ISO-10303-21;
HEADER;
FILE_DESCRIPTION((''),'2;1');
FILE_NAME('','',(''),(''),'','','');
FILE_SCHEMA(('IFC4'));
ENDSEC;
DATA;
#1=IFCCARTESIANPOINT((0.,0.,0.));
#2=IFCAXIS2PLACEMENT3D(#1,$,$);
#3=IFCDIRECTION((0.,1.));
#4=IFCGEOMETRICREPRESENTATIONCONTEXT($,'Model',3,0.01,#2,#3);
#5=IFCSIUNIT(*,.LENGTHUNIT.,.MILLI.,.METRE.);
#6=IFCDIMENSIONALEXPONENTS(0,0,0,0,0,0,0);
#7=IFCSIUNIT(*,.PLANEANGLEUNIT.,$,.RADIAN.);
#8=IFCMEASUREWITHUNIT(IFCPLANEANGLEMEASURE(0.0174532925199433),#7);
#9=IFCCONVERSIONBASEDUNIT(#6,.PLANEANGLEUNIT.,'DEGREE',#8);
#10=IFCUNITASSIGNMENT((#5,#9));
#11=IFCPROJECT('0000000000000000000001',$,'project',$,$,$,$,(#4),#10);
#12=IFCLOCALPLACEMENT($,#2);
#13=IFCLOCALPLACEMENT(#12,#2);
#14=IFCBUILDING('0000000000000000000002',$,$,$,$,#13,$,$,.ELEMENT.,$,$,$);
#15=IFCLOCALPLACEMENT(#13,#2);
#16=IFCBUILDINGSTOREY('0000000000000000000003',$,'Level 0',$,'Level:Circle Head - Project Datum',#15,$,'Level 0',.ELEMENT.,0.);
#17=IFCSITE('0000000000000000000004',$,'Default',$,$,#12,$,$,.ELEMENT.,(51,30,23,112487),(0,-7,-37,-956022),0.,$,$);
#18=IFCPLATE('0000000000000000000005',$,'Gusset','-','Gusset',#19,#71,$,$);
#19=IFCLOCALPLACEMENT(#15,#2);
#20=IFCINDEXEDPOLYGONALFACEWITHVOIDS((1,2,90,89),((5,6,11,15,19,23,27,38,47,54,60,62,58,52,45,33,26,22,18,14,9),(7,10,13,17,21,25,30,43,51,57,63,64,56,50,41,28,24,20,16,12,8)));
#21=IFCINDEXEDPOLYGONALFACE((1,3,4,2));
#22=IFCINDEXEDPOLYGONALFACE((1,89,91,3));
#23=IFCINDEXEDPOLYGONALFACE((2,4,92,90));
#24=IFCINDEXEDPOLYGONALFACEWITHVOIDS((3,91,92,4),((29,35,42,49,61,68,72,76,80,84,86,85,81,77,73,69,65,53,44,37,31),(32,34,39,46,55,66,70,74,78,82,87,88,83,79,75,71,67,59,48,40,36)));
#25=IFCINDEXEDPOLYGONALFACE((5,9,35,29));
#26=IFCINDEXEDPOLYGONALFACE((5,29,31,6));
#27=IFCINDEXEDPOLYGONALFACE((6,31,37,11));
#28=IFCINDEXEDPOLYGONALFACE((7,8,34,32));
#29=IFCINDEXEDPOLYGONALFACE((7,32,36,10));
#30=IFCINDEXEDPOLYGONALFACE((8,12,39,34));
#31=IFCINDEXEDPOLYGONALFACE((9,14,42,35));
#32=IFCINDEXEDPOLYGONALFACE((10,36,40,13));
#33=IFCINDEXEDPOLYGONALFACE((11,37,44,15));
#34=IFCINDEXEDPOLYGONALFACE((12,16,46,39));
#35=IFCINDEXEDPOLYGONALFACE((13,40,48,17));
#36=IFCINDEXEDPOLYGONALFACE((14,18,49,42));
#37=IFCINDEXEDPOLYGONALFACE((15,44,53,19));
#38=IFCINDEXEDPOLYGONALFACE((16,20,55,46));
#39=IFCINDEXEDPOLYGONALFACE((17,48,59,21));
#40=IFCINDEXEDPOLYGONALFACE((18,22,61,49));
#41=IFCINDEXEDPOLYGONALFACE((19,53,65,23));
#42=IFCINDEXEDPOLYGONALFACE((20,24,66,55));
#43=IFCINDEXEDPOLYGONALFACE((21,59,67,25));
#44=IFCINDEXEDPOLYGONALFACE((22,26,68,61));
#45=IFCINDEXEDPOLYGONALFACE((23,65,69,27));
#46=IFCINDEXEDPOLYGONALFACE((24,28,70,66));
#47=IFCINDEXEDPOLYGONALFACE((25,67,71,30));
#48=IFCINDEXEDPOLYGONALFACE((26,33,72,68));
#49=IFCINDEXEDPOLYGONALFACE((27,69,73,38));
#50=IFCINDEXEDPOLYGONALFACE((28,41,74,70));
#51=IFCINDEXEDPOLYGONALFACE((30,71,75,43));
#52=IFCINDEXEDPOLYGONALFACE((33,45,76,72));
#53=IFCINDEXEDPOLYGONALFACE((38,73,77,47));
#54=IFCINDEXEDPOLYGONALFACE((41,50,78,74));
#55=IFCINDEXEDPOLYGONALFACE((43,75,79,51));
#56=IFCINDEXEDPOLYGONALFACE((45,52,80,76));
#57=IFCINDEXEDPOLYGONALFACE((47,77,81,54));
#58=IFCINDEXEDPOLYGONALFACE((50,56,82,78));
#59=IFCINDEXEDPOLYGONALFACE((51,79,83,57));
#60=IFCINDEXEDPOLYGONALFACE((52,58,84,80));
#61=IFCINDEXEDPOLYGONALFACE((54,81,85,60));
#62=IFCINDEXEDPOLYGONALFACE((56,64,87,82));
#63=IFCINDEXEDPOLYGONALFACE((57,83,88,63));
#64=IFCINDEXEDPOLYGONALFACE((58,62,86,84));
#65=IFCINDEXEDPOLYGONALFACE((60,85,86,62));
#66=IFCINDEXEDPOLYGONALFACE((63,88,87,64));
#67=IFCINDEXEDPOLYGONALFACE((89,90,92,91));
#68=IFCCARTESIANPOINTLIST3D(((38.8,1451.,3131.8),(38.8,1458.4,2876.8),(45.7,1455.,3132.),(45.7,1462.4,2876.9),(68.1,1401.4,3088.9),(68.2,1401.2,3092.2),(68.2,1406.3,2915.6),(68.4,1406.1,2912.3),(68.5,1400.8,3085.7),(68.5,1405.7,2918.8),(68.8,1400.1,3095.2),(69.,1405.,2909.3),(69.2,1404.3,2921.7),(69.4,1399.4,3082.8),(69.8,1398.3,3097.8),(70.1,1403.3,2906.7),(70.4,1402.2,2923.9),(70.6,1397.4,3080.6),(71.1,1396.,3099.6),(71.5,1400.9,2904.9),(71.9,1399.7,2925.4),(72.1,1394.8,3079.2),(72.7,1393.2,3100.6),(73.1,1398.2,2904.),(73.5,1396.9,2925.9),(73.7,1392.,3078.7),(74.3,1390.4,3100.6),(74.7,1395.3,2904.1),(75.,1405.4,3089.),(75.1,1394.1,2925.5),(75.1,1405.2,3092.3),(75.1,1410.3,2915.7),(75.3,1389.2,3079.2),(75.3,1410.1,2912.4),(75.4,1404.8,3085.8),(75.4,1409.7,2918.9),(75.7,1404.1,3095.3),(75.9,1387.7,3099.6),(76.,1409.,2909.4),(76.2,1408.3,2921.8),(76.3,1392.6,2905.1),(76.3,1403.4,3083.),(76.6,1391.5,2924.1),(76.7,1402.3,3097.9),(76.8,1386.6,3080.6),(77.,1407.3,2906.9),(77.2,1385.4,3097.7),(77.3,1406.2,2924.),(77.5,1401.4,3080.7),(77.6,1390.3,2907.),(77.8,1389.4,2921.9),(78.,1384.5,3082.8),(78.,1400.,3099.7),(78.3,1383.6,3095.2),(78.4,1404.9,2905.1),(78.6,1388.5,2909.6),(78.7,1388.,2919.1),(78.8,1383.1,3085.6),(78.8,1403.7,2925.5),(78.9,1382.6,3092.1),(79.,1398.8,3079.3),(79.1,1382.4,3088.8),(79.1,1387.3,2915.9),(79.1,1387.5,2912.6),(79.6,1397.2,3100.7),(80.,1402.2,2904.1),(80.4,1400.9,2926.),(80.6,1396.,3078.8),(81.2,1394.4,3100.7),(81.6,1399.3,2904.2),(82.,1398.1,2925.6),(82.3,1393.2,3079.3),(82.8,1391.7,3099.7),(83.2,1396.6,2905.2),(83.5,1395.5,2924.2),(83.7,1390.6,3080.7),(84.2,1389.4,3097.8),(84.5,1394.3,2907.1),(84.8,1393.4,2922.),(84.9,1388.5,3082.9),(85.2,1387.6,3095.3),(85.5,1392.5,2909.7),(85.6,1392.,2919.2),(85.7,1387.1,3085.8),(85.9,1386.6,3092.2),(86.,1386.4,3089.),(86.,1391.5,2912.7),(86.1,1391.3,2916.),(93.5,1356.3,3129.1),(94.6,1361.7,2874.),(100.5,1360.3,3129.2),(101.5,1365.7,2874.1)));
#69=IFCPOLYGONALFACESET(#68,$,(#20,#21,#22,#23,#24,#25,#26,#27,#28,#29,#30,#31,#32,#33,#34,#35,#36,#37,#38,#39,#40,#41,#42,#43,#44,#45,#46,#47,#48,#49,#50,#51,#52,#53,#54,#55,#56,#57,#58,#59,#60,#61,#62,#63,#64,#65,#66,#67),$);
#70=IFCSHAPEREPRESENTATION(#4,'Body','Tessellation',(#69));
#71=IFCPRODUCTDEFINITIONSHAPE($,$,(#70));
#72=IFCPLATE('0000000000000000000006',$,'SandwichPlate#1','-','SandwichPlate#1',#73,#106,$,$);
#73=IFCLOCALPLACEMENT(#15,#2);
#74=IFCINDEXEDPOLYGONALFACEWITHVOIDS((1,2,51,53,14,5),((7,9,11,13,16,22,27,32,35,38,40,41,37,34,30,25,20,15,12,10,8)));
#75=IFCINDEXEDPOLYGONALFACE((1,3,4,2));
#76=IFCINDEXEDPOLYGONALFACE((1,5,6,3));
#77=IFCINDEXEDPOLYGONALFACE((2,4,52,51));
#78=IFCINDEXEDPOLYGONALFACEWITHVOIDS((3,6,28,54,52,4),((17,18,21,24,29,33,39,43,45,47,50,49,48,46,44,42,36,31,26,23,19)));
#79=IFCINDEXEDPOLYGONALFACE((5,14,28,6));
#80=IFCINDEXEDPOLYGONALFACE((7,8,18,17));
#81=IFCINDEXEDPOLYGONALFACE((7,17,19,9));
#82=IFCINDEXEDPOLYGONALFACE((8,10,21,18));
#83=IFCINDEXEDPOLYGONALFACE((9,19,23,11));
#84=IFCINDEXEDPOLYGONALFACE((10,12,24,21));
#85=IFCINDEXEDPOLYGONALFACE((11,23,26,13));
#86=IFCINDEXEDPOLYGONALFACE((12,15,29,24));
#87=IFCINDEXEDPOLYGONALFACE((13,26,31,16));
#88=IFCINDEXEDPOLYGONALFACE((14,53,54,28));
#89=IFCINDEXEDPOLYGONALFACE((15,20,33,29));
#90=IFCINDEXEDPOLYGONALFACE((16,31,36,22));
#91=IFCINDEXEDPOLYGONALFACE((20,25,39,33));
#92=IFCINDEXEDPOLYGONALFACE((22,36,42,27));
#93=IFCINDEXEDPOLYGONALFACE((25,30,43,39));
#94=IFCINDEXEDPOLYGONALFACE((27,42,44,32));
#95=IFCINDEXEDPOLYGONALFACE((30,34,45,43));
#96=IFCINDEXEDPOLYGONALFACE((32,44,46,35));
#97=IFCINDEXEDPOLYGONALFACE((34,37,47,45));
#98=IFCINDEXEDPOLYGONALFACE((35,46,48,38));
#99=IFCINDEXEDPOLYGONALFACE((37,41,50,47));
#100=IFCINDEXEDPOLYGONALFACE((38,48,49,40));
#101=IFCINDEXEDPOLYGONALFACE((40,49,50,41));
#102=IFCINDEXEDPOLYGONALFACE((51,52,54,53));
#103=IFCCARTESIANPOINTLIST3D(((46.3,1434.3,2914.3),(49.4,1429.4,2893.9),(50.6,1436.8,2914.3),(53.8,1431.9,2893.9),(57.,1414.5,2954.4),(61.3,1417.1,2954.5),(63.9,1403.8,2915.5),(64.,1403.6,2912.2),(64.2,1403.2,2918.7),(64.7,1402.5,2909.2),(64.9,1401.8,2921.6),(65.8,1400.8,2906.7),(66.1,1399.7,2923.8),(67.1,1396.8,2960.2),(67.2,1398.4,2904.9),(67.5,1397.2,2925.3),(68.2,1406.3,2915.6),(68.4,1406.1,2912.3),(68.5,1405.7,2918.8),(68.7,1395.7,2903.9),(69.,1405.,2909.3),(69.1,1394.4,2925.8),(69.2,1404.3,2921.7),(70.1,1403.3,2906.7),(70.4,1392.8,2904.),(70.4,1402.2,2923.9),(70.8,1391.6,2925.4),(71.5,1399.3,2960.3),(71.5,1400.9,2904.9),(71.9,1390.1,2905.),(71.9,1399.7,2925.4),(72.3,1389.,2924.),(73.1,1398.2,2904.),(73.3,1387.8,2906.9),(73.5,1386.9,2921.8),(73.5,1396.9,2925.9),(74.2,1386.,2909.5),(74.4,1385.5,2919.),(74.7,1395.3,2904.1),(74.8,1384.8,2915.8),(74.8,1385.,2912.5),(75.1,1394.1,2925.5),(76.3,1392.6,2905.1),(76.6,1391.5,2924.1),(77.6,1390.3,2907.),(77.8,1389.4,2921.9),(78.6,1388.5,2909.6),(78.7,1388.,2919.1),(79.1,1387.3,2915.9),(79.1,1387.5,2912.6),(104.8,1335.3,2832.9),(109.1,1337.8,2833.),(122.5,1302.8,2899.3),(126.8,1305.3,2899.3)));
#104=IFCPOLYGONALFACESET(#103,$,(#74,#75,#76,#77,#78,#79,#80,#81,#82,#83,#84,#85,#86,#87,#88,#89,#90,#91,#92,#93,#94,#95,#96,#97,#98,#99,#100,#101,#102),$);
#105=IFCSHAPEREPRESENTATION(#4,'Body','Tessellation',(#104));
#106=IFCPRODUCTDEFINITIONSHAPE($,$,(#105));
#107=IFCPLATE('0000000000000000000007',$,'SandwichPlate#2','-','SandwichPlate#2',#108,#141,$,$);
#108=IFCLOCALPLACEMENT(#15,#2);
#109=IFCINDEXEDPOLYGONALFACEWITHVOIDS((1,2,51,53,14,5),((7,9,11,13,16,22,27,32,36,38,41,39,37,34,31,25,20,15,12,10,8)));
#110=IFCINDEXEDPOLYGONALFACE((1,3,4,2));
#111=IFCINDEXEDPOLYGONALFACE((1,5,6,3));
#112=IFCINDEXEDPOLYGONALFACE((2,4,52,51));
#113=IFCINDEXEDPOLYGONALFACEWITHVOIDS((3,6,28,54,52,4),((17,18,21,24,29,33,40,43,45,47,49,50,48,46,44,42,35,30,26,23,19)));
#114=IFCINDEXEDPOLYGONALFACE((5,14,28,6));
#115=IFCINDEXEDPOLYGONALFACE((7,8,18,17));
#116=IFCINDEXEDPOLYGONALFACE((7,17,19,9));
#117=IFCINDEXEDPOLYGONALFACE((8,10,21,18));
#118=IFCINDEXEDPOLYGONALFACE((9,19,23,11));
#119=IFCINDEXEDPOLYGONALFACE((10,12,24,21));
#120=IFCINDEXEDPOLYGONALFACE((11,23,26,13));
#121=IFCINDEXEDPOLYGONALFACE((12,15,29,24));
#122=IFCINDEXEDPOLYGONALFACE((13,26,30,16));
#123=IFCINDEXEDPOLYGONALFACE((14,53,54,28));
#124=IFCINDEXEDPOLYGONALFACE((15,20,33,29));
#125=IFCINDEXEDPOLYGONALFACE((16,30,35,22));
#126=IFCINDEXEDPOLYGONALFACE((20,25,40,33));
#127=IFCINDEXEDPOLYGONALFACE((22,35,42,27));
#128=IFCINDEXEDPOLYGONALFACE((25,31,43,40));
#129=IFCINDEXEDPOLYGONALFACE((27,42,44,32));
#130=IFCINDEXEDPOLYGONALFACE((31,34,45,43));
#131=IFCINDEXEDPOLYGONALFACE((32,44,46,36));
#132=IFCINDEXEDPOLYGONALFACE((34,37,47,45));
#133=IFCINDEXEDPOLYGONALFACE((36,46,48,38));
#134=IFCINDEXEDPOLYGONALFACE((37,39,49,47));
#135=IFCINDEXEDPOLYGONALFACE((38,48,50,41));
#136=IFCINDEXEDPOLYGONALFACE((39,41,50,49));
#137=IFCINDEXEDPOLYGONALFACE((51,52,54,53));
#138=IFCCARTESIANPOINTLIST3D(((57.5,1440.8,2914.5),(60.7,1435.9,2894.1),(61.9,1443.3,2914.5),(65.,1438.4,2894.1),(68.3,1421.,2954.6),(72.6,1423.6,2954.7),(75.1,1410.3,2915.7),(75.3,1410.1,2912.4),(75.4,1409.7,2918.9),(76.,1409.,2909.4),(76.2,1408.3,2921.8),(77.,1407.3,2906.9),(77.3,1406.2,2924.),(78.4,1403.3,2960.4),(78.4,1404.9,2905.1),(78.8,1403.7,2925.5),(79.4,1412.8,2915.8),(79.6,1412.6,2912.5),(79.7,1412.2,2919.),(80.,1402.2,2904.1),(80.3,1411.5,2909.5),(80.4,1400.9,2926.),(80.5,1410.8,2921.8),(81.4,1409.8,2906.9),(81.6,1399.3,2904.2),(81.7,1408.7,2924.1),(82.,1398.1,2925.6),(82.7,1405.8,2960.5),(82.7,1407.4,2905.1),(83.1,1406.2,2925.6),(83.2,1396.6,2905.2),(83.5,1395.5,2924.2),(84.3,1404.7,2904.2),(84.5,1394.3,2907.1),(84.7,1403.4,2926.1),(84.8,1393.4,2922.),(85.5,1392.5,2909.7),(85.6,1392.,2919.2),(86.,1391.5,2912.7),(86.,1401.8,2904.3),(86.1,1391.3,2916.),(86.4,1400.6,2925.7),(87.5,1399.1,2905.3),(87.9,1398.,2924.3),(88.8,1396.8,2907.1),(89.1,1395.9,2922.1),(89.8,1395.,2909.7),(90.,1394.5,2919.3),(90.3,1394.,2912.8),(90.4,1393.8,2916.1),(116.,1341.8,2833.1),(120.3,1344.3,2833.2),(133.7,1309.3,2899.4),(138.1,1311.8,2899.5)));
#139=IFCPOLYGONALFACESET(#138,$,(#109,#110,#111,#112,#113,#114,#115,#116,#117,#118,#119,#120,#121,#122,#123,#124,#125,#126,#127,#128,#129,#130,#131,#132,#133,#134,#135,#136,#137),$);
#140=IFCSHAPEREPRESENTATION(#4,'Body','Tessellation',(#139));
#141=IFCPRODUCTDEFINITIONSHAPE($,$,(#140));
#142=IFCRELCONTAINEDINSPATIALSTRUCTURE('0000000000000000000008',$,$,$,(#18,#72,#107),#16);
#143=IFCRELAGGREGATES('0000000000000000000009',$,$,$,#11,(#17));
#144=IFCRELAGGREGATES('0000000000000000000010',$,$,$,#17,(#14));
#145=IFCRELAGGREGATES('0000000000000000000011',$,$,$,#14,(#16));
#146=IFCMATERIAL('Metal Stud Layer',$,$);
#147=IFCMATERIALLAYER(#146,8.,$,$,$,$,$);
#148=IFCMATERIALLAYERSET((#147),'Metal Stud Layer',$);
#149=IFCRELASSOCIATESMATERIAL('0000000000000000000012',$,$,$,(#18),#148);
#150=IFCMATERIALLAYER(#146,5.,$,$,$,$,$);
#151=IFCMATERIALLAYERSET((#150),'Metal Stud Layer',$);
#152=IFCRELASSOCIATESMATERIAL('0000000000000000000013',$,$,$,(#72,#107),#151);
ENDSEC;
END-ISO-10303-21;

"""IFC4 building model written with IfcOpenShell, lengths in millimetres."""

from ifc_helpers import new_model, entity, si_unit, converted_unit, direction, frame, origin, origin_with_axes, origin_2d_with_axis, place, context, project, spatial, polyline, circle, outline, extrude, material, layer, layer_set, element, save


model = new_model("IFC4")

# Units and contexts
model_context = context("Model", 3, precision=0.01, world=origin(), true_north=direction((0.0, 1.0)))
ifc_project = project(units=[si_unit("LENGTHUNIT", "METRE", prefix="MILLI"), converted_unit("PLANEANGLEUNIT", "DEGREE", entity("IfcPlaneAngleMeasure", 0.0174532925199433), si_unit("PLANEANGLEUNIT", "RADIAN"), dimensions=[0, 0, 0, 0, 0, 0, 0])], contexts=[model_context])

# Site, building, storey
site_placement = place(None, origin())
site = spatial("IfcSite", under=ifc_project, at=site_placement, Name="Default", CompositionType="ELEMENT", RefLatitude=(51, 30, 23, 112487), RefLongitude=(0, -7, -37, -956022), RefElevation=0.0)
building_placement = place(site_placement, origin())
building = spatial("IfcBuilding", under=site, at=building_placement, CompositionType="ELEMENT")
storey_placement = place(building_placement, origin())
storey = spatial("IfcBuildingStorey", under=building, at=storey_placement, Name="Level 0", ObjectType="Level:Circle Head - Project Datum", LongName="Level 0", CompositionType="ELEMENT", Elevation=0.0)

# Plates, openings
ifc_material = material(Name="Metal Stud Layer")
ifc_layer_1 = layer(ifc_material, 8.0)
ifc_layer_set_1 = layer_set([ifc_layer_1], Name="Metal Stud Layer")
plate_1_placement = place(storey_placement, frame((46.7, 1453.3, 3131.9), z_axis=(-0.865935, -0.499948, -0.014432), x_axis=(0.0, 0.028855, -0.999584)))
plate_1 = element("IfcPlate", 1, at=plate_1_placement, inside=storey, material=ifc_layer_set_1, Name="Gusset", Description="-", ObjectType="Gusset", context=model_context, shape_type="SweptSolid", body=[
    extrude(outline(polyline([(0.0, -2.0), (255.1, -2.0), (255.1, 109.6), (0.0, 107.5), (0.0, -2.0)])), origin_with_axes(), (0.0, 0.0, 1.0), 8.0),
])
opening_1_placement = place(plate_1_placement, frame((40.4, 67.6, 8.5), z_axis=(0.0, 0.0, -1.0), x_axis=(-0.519479, 0.854483, 0.0)))
element("IfcOpeningElement", 2, at=opening_1_placement, cuts=plate_1, ObjectType="Opening", context=model_context, shape_type="SweptSolid", body=[
    extrude(circle(Radius=11.0, at=origin_2d_with_axis()), origin(), (0.0, 0.0, 1.0), 9.0),
])
opening_2_placement = place(plate_1_placement, frame((215.3, 67.8, 8.5), z_axis=(0.0, 0.0, -1.0), x_axis=(0.465705, 0.88494, 0.0)))
element("IfcOpeningElement", 3, at=opening_2_placement, cuts=plate_1, ObjectType="Opening", context=model_context, shape_type="SweptSolid", body=[
    extrude(circle(Radius=11.0, at=origin_2d_with_axis()), origin(), (0.0, 0.0, 1.0), 9.0),
])
ifc_layer_2 = layer(ifc_material, 5.0)
ifc_layer_set_2 = layer_set([ifc_layer_2], Name="Metal Stud Layer")
plate_2_placement = place(storey_placement, frame((42.8, 1440.7, 2901.2), z_axis=(0.865935, 0.499948, 0.014432), x_axis=(0.232925, -0.428638, 0.872935)))
plate_2 = element("IfcPlate", 4, at=plate_2_placement, inside=storey, material=ifc_layer_set_2, Name="SandwichPlate#1", Description="-", ObjectType="SandwichPlate#1", context=model_context, shape_type="SweptSolid", body=[
    extrude(outline(polyline([(0.0, 0.0), (76.0, 0.0), (76.0, 140.0), (0.0, 140.0), (0.0, 0.0)])), origin_with_axes(), (0.0, 0.0, 1.0), 5.0),
])
opening_3_placement = place(plate_2_placement, frame((0.0, 0.0, 0.0), z_axis=(0.0, 0.0, 1.0), x_axis=(1.0, 0.0, 0.0)))
element("IfcOpeningElement", 5, at=opening_3_placement, cuts=plate_2, ObjectType="Opening", context=model_context, shape_type="SweptSolid", body=[
    extrude(outline(polyline([(0.0, 0.0), (15.0, 0.0), (0.0, 15.0), (0.0, 0.0)])), origin(), (0.0, 0.0, 1.0), 5.0),
])
opening_4_placement = place(plate_2_placement, frame((0.0, 0.0, 0.0), z_axis=(0.0, 0.0, 1.0), x_axis=(1.0, 0.0, 0.0)))
element("IfcOpeningElement", 6, at=opening_4_placement, cuts=plate_2, ObjectType="Opening", context=model_context, shape_type="SweptSolid", body=[
    extrude(outline(polyline([(76.0, 0.0), (76.0, 15.0), (61.0, 0.0), (76.0, 0.0)])), origin(), (0.0, 0.0, 1.0), 5.0),
])
opening_5_placement = place(plate_2_placement, frame((38.0, 40.0, -0.5), z_axis=(0.0, 0.0, 1.0), x_axis=(0.0, 1.0, 0.0)))
element("IfcOpeningElement", 7, at=opening_5_placement, cuts=plate_2, ObjectType="Opening", context=model_context, shape_type="SweptSolid", body=[
    extrude(circle(Radius=11.0, at=origin_2d_with_axis()), origin(), (0.0, 0.0, 1.0), 6.0),
])
plate_3_placement = place(storey_placement, frame((54.1, 1447.2, 2901.4), z_axis=(0.865935, 0.499948, 0.014432), x_axis=(0.232925, -0.428638, 0.872935)))
plate_3 = element("IfcPlate", 8, at=plate_3_placement, inside=storey, material=ifc_layer_set_2, Name="SandwichPlate#2", Description="-", ObjectType="SandwichPlate#2", context=model_context, shape_type="SweptSolid", body=[
    extrude(outline(polyline([(0.0, 0.0), (76.0, 0.0), (76.0, 140.0), (0.0, 140.0), (0.0, 0.0)])), origin_with_axes(), (0.0, 0.0, 1.0), 5.0),
])
opening_6_placement = place(plate_3_placement, frame((0.0, 0.0, 0.0), z_axis=(0.0, 0.0, 1.0), x_axis=(1.0, 0.0, 0.0)))
element("IfcOpeningElement", 9, at=opening_6_placement, cuts=plate_3, ObjectType="Opening", context=model_context, shape_type="SweptSolid", body=[
    extrude(outline(polyline([(0.0, 0.0), (15.0, 0.0), (0.0, 15.0), (0.0, 0.0)])), origin(), (0.0, 0.0, 1.0), 5.0),
])
opening_7_placement = place(plate_3_placement, frame((0.0, 0.0, 0.0), z_axis=(0.0, 0.0, 1.0), x_axis=(1.0, 0.0, 0.0)))
element("IfcOpeningElement", 10, at=opening_7_placement, cuts=plate_3, ObjectType="Opening", context=model_context, shape_type="SweptSolid", body=[
    extrude(outline(polyline([(76.0, 0.0), (76.0, 15.0), (61.0, 0.0), (76.0, 0.0)])), origin(), (0.0, 0.0, 1.0), 5.0),
])
opening_8_placement = place(plate_3_placement, frame((38.0, 40.0, -0.5), z_axis=(0.0, 0.0, 1.0), x_axis=(0.0, 1.0, 0.0)))
element("IfcOpeningElement", 11, at=opening_8_placement, cuts=plate_3, ObjectType="Opening", context=model_context, shape_type="SweptSolid", body=[
    extrude(circle(Radius=11.0, at=origin_2d_with_axis()), origin(), (0.0, 0.0, 1.0), 6.0),
])

save(model, "model.ifc")
